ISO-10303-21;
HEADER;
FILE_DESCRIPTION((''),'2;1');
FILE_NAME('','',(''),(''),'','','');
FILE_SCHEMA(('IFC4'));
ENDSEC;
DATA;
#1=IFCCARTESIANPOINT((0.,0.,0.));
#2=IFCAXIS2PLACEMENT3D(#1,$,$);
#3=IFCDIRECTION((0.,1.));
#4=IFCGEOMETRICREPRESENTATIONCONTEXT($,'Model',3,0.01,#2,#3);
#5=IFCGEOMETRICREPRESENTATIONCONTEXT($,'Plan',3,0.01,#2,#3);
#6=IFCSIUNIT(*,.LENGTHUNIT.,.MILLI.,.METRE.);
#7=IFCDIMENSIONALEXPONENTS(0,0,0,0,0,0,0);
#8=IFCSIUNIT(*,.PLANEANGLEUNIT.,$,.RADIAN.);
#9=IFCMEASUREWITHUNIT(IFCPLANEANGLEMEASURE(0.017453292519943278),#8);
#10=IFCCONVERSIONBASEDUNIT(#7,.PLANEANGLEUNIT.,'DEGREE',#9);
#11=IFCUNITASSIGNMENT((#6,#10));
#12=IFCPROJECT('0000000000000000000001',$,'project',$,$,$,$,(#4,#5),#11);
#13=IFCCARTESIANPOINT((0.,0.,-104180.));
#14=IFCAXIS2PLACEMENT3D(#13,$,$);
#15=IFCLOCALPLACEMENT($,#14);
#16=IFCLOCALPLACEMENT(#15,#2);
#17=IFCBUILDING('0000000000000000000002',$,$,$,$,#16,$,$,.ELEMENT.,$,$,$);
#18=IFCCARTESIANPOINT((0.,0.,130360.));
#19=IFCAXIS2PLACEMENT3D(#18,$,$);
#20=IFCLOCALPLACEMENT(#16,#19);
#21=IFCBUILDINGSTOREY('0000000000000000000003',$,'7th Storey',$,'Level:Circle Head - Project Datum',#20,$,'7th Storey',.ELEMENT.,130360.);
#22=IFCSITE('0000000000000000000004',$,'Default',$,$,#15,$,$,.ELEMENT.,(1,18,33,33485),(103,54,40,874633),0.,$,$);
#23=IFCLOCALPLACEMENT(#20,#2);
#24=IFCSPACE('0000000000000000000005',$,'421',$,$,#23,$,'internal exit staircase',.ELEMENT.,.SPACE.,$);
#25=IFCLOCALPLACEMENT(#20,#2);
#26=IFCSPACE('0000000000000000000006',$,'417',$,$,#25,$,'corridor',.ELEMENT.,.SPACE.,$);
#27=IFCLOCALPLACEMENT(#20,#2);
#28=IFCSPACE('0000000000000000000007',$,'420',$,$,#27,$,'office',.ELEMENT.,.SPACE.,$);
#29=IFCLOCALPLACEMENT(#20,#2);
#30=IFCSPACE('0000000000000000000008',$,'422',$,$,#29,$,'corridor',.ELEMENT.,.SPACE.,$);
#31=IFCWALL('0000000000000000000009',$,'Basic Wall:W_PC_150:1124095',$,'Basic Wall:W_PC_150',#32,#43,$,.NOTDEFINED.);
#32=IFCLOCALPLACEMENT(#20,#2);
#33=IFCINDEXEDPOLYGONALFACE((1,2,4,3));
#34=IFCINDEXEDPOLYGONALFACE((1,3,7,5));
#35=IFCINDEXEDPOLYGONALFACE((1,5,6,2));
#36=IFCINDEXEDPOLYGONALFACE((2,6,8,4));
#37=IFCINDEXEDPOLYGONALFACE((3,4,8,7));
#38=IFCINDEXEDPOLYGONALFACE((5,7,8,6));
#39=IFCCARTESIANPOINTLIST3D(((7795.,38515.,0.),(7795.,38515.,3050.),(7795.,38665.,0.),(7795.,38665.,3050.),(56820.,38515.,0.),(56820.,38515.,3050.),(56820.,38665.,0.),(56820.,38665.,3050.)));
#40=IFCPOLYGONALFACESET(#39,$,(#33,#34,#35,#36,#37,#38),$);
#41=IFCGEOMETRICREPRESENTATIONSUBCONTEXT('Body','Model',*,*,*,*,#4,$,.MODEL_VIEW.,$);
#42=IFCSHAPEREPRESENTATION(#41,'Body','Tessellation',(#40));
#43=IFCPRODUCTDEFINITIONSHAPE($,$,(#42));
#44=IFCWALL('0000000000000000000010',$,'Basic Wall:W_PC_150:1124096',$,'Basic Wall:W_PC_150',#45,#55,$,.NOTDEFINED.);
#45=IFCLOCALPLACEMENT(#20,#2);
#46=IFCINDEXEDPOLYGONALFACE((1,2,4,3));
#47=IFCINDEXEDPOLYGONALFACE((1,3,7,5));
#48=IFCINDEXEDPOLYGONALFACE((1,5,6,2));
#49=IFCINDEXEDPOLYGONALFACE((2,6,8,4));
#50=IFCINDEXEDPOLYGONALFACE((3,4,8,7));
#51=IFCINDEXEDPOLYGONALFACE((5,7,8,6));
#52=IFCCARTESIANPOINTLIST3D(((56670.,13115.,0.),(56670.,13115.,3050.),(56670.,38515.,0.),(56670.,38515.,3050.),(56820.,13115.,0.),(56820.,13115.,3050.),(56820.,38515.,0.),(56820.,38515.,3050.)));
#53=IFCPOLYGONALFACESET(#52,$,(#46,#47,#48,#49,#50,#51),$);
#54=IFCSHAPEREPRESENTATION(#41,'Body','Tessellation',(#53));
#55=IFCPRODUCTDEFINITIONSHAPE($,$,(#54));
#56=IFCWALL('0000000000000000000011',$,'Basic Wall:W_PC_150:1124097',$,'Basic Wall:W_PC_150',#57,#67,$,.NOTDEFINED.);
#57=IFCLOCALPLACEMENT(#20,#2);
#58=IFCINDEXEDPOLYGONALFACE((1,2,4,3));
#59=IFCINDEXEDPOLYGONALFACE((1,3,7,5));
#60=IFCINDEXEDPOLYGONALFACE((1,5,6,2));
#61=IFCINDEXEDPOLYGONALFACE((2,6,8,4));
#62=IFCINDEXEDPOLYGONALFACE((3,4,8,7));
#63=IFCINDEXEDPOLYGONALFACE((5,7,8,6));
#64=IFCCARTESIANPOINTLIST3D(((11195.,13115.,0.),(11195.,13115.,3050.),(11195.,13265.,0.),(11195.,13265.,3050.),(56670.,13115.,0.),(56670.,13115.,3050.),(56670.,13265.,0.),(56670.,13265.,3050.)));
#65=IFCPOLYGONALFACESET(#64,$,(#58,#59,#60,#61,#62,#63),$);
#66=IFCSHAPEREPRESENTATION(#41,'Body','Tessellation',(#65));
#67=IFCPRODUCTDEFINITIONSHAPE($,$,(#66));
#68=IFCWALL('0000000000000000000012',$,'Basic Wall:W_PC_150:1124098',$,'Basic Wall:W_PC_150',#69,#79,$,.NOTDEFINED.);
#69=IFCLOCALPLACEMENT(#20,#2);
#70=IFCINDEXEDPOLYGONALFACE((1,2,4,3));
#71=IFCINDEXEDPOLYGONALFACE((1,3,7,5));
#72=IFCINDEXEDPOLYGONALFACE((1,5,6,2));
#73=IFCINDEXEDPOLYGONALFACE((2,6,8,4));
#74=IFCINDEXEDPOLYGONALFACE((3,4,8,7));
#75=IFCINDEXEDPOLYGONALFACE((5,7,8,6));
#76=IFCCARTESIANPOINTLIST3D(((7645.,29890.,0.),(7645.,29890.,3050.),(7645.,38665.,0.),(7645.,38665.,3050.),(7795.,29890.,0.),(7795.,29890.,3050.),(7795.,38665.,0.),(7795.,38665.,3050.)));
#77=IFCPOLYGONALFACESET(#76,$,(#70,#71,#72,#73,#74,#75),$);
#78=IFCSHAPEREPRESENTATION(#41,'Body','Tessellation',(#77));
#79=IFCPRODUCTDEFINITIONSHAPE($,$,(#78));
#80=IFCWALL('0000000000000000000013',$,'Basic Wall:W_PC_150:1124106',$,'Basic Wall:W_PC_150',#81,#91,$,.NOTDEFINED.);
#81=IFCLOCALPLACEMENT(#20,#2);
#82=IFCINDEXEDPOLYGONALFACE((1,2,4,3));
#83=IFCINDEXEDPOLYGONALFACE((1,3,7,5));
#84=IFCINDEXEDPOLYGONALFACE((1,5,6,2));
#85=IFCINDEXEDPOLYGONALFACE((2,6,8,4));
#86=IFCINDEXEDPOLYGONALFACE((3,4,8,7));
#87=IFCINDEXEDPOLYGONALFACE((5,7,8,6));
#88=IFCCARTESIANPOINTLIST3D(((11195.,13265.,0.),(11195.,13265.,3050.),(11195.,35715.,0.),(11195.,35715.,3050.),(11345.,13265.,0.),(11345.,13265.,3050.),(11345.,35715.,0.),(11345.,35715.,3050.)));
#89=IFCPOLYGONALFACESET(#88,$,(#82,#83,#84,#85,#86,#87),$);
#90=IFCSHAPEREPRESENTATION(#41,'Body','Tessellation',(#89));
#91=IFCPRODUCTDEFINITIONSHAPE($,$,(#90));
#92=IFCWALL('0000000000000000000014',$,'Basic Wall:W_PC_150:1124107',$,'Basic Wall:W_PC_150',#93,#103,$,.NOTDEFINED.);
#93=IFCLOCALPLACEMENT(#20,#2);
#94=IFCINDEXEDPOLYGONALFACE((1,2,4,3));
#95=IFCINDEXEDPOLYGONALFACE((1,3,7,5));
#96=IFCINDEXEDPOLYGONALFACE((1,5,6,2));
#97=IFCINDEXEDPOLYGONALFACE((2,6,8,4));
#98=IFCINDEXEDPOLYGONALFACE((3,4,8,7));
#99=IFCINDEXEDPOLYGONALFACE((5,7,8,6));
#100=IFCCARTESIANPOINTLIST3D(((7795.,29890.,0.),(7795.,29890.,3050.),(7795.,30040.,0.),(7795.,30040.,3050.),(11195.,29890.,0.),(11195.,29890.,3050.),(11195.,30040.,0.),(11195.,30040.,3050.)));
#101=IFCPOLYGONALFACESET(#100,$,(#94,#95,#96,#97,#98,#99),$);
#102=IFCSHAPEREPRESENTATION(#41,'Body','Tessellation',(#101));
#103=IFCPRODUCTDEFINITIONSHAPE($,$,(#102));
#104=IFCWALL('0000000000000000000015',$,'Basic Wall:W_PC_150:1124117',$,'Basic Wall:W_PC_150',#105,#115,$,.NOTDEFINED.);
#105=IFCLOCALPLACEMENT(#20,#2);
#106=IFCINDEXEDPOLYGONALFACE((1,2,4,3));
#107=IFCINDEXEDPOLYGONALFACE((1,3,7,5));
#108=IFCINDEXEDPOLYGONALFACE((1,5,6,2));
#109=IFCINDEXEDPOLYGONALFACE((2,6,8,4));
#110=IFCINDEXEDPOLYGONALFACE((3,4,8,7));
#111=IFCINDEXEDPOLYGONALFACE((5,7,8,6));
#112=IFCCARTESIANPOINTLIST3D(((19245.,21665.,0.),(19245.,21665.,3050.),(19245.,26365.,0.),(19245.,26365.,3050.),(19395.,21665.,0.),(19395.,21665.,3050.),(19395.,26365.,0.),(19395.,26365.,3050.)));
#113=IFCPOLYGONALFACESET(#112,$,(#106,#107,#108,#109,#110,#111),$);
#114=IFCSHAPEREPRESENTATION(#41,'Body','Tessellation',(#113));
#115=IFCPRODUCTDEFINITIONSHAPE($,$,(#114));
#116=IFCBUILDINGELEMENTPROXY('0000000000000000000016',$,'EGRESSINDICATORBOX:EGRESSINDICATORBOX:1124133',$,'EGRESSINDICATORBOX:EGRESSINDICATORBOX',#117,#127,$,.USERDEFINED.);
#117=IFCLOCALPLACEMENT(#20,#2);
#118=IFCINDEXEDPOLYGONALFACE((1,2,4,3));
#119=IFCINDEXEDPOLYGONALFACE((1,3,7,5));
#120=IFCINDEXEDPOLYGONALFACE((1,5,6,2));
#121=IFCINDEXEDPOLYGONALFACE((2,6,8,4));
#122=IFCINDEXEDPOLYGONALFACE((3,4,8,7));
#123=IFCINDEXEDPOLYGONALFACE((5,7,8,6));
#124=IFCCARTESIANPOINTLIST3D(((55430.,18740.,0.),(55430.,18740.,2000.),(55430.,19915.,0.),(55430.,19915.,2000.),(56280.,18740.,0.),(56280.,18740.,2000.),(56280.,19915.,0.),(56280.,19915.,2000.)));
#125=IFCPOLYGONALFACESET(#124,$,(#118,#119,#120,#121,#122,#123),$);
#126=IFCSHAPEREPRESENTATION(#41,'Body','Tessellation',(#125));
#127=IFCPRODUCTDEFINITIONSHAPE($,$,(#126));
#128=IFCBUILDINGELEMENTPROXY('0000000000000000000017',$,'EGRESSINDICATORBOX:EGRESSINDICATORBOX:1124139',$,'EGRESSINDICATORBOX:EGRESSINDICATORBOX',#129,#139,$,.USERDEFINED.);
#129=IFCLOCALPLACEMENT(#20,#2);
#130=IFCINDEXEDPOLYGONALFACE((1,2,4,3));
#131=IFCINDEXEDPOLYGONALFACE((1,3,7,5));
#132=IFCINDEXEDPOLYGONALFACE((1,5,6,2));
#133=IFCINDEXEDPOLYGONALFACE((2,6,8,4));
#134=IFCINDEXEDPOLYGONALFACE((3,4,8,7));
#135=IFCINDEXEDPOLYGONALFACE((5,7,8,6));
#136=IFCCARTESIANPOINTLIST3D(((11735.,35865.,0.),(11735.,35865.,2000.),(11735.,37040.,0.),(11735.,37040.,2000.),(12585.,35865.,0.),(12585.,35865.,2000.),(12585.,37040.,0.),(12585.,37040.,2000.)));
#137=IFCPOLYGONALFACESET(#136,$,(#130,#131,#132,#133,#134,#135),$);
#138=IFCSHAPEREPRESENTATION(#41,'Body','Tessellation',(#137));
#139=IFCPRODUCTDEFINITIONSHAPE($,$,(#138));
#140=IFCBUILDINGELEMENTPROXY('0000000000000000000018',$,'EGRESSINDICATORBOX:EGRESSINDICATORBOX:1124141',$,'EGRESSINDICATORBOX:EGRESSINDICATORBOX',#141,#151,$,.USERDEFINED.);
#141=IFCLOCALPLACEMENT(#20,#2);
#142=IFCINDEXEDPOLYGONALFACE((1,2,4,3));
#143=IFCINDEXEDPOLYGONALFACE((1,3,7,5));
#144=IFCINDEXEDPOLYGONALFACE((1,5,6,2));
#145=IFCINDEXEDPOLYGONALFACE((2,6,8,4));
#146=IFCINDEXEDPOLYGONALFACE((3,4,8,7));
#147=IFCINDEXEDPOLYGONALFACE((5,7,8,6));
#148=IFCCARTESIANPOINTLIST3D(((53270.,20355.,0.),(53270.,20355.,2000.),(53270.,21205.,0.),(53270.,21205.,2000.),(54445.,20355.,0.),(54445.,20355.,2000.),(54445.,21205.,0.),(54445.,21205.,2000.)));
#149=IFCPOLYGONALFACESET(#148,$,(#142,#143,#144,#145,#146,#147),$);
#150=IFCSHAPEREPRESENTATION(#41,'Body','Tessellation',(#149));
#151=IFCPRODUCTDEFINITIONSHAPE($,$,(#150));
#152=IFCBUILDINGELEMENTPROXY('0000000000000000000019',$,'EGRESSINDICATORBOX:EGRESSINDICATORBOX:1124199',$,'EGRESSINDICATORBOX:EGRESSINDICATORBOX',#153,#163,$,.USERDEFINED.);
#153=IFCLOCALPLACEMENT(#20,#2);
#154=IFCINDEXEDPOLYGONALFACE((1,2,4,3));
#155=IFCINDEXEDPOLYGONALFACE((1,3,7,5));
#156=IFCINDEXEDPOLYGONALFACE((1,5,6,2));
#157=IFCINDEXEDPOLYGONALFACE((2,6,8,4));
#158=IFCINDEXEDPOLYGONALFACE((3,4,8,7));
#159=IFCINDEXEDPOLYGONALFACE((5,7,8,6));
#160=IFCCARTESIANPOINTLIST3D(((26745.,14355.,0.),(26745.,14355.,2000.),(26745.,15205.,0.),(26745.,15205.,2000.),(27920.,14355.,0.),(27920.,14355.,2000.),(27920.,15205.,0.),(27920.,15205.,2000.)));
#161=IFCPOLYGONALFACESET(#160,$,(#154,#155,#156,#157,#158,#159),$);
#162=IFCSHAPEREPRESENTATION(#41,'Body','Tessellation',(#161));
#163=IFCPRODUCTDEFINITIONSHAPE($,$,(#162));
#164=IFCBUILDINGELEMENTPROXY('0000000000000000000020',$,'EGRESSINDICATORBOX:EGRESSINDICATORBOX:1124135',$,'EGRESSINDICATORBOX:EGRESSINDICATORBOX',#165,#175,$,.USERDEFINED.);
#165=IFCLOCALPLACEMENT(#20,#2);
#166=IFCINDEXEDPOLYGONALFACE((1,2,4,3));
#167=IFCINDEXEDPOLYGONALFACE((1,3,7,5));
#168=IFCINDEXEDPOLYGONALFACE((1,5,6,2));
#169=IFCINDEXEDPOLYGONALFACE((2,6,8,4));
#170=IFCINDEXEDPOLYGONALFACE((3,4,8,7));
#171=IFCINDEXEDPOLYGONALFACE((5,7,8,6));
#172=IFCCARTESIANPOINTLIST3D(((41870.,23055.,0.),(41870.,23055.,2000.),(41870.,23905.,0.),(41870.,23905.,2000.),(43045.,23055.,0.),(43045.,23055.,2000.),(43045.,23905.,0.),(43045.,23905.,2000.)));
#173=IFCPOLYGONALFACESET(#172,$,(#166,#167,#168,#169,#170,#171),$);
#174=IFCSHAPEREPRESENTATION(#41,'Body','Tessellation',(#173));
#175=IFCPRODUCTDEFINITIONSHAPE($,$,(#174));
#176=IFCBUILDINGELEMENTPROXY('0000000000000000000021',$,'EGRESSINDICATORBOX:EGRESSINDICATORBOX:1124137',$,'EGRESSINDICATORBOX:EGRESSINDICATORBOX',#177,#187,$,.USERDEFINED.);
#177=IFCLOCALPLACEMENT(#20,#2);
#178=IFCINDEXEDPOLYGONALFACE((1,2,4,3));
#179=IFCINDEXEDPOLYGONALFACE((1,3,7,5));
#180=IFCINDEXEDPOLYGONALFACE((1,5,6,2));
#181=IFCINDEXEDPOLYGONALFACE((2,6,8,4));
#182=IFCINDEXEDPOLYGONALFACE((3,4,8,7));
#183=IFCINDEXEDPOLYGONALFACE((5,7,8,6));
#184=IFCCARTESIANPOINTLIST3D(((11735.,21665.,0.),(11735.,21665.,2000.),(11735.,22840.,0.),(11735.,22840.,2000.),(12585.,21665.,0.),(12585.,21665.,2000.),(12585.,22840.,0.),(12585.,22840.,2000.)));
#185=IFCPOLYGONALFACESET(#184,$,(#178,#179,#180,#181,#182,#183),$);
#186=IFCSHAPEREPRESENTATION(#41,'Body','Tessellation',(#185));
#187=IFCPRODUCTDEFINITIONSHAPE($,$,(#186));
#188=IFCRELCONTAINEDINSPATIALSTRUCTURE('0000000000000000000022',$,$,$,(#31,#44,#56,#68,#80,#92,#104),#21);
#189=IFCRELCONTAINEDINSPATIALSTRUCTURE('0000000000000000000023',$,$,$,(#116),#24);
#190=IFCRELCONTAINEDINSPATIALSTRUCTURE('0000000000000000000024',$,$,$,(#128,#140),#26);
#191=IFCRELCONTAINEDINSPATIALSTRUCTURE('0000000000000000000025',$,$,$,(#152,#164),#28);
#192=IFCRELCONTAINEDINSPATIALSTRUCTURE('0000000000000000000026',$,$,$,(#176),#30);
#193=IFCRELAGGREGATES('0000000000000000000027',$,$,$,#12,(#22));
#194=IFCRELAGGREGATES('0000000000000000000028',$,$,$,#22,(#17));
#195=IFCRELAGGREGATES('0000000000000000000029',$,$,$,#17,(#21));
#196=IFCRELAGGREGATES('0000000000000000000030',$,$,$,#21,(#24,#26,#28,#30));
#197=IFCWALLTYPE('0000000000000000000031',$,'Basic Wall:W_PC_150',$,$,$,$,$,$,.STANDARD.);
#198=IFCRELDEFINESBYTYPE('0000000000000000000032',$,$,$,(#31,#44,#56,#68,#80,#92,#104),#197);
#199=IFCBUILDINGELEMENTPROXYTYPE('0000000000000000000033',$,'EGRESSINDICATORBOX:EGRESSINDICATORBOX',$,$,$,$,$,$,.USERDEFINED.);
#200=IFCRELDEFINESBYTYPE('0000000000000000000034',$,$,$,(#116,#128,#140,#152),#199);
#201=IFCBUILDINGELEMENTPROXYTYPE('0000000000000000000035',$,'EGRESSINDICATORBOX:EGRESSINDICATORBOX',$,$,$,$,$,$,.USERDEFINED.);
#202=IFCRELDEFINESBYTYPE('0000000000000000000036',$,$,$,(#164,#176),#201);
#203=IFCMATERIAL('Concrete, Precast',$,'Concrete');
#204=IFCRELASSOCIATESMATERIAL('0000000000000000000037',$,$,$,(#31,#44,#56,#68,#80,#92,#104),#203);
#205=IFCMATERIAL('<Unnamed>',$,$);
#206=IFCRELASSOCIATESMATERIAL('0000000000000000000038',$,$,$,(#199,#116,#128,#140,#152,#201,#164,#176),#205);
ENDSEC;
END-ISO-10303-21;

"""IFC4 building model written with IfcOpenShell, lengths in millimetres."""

from ifc_helpers import new_model, entity, si_unit, converted_unit, direction, frame, origin, place, context, subcontext, project, spatial, indexed_curve, outline, extrude, source, transform, mapped, material, type_object, type_shapes, element, save


model = new_model("IFC4")

# Units and contexts
model_context = context("Model", 3, precision=0.01, world=origin(), true_north=direction((0.0, 1.0)))
plan_context = context("Plan", 3, precision=0.01, world=origin(), true_north=direction((0.0, 1.0)))
body_context = subcontext(model_context, "Body", "Model", "MODEL_VIEW")
ifc_project = project(units=[si_unit("LENGTHUNIT", "METRE", prefix="MILLI"), converted_unit("PLANEANGLEUNIT", "DEGREE", entity("IfcPlaneAngleMeasure", 0.017453292519943278), si_unit("PLANEANGLEUNIT", "RADIAN"), dimensions=[0, 0, 0, 0, 0, 0, 0])], contexts=[model_context, plan_context])

# Site, building, storey
site_placement = place(None, frame((0.0, 0.0, -104180.0)))
site = spatial("IfcSite", under=ifc_project, at=site_placement, Name="Default", CompositionType="ELEMENT", RefLatitude=(1, 18, 33, 33485), RefLongitude=(103, 54, 40, 874633), RefElevation=0.0)
building_placement = place(site_placement, origin())
building = spatial("IfcBuilding", under=site, at=building_placement, CompositionType="ELEMENT")
storey_placement = place(building_placement, frame((0.0, 0.0, 130360.0)))
storey = spatial("IfcBuildingStorey", under=building, at=storey_placement, Name="7th Storey", ObjectType="Level:Circle Head - Project Datum", LongName="7th Storey", CompositionType="ELEMENT", Elevation=130360.0)

# Shared definitions
ifc_material_1 = material(Name="Concrete, Precast", Category="Concrete")

# Walls
wall_type = type_object("IfcWallType", Name="Basic Wall:W_PC_150", PredefinedType="STANDARD")
wall_1_placement = place(storey_placement, frame((56820.0, 38590.0, 0.0), z_axis=(0.0, 0.0, 1.0), x_axis=(-1.0, 0.0, 0.0)))
element("IfcWall", 1, at=wall_1_placement, inside=storey, type_object=wall_type, material=ifc_material_1, Name="Basic Wall:W_PC_150:1124095", ObjectType="Basic Wall:W_PC_150", PredefinedType="NOTDEFINED", context=body_context, shape_type="SweptSolid", body=[
    extrude(outline(indexed_curve([(49025.0, 75.0), (0.0, 75.0), (0.0, -75.0), (49025.0, -75.0), (49025.0, 75.0)], self_intersect=False)), origin(), (0.0, 0.0, 1.0), 3050.0),
])
wall_2_placement = place(storey_placement, frame((56745.0, 13115.0, 0.0), z_axis=(0.0, 0.0, 1.0), x_axis=(0.0, 1.0, 0.0)))
element("IfcWall", 2, at=wall_2_placement, inside=storey, type_object=wall_type, material=ifc_material_1, Name="Basic Wall:W_PC_150:1124096", ObjectType="Basic Wall:W_PC_150", PredefinedType="NOTDEFINED", context=body_context, shape_type="SweptSolid", body=[
    extrude(outline(indexed_curve([(25400.0, 75.0), (0.0, 75.0), (0.0, -75.0), (25400.0, -75.0), (25400.0, 75.0)], self_intersect=False)), origin(), (0.0, 0.0, 1.0), 3050.0),
])
wall_3_placement = place(storey_placement, frame((11195.0, 13190.0, 0.0)))
element("IfcWall", 3, at=wall_3_placement, inside=storey, type_object=wall_type, material=ifc_material_1, Name="Basic Wall:W_PC_150:1124097", ObjectType="Basic Wall:W_PC_150", PredefinedType="NOTDEFINED", context=body_context, shape_type="SweptSolid", body=[
    extrude(outline(indexed_curve([(45475.0, 75.0), (0.0, 75.0), (0.0, -75.0), (45475.0, -75.0), (45475.0, 75.0)], self_intersect=False)), origin(), (0.0, 0.0, 1.0), 3050.0),
])
wall_4_placement = place(storey_placement, frame((7720.0, 38665.0, 0.0), z_axis=(0.0, 0.0, 1.0), x_axis=(0.0, -1.0, 0.0)))
element("IfcWall", 4, at=wall_4_placement, inside=storey, type_object=wall_type, material=ifc_material_1, Name="Basic Wall:W_PC_150:1124098", ObjectType="Basic Wall:W_PC_150", PredefinedType="NOTDEFINED", context=body_context, shape_type="SweptSolid", body=[
    extrude(outline(indexed_curve([(8775.0, 75.0), (0.0, 75.0), (0.0, -75.0), (8775.0, -75.0), (8775.0, 75.0)], self_intersect=False)), origin(), (0.0, 0.0, 1.0), 3050.0),
])
wall_5_placement = place(storey_placement, frame((11270.0, 35715.0, 0.0), z_axis=(0.0, 0.0, 1.0), x_axis=(0.0, -1.0, 0.0)))
element("IfcWall", 5, at=wall_5_placement, inside=storey, type_object=wall_type, material=ifc_material_1, Name="Basic Wall:W_PC_150:1124106", ObjectType="Basic Wall:W_PC_150", PredefinedType="NOTDEFINED", context=body_context, shape_type="SweptSolid", body=[
    extrude(outline(indexed_curve([(22450.0, 75.0), (0.0, 75.0), (0.0, -75.0), (22450.0, -75.0), (22450.0, 75.0)], self_intersect=False)), origin(), (0.0, 0.0, 1.0), 3050.0),
])
wall_6_placement = place(storey_placement, frame((7795.0, 29965.0, 0.0)))
element("IfcWall", 6, at=wall_6_placement, inside=storey, type_object=wall_type, material=ifc_material_1, Name="Basic Wall:W_PC_150:1124107", ObjectType="Basic Wall:W_PC_150", PredefinedType="NOTDEFINED", context=body_context, shape_type="SweptSolid", body=[
    extrude(outline(indexed_curve([(3400.0, 75.0), (0.0, 75.0), (0.0, -75.0), (3400.0, -75.0), (3400.0, 75.0)], self_intersect=False)), origin(), (0.0, 0.0, 1.0), 3050.0),
])
wall_7_placement = place(storey_placement, frame((19320.0, 21665.0, 0.0), z_axis=(0.0, 0.0, 1.0), x_axis=(0.0, 1.0, 0.0)))
element("IfcWall", 7, at=wall_7_placement, inside=storey, type_object=wall_type, material=ifc_material_1, Name="Basic Wall:W_PC_150:1124117", ObjectType="Basic Wall:W_PC_150", PredefinedType="NOTDEFINED", context=body_context, shape_type="SweptSolid", body=[
    extrude(outline(indexed_curve([(4700.0, 75.0), (0.0, 75.0), (0.0, -75.0), (4700.0, -75.0), (4700.0, 75.0)], self_intersect=False)), origin(), (0.0, 0.0, 1.0), 3050.0),
])

# Shared definitions
space_1_placement = place(storey_placement, origin())
space_1 = spatial("IfcSpace", under=storey, at=space_1_placement, Name="421", LongName="internal exit staircase", CompositionType="ELEMENT", PredefinedType="SPACE")

# Building element proxy
ifc_material_2 = material(Name="<Unnamed>")
building_element_proxy_type_1 = type_object("IfcBuildingElementProxyType", Name="EGRESSINDICATORBOX:EGRESSINDICATORBOX", PredefinedType="USERDEFINED", material=ifc_material_2)
shared_shape_1 = source(origin(), body_context, "Body", "SweptSolid", [
    extrude(outline(indexed_curve([(-587.5, -425.0), (587.5, -425.0), (587.5, 425.0), (-587.5, 425.0), (-587.5, -425.0)], self_intersect=False)), frame((0.0, 0.0, 0.0), z_axis=(0.0, 0.0, 1.0), x_axis=(0.0, 1.0, 0.0)), (0.0, 0.0, 1.0), 2000.0),
])
type_shapes(building_element_proxy_type_1, [shared_shape_1])
proxy_1_placement = place(space_1_placement, frame((55855.0, 19327.5, 0.0)))
element("IfcBuildingElementProxy", 8, at=proxy_1_placement, inside=space_1, type_object=building_element_proxy_type_1, material=ifc_material_2, Name="EGRESSINDICATORBOX:EGRESSINDICATORBOX:1124133", ObjectType="EGRESSINDICATORBOX:EGRESSINDICATORBOX", PredefinedType="USERDEFINED", context=body_context, shape_type="MappedRepresentation", body=[
    mapped(shared_shape_1, transform((0.0, 0.0, 0.0), scale=1.0)),
])

# Shared definitions
space_2_placement = place(storey_placement, origin())
space_2 = spatial("IfcSpace", under=storey, at=space_2_placement, Name="417", LongName="corridor", CompositionType="ELEMENT", PredefinedType="SPACE")

# Building element proxies
for number, where, z_axis, x_axis, name in (
    (9, (12160.0, 36452.5, 0.0), (0.0, 0.0, 1.0), (-1.0, 0.0, 0.0), "EGRESSINDICATORBOX:EGRESSINDICATORBOX:1124139"),
    (10, (53857.5, 20780.0, 0.0), (0.0, 0.0, 1.0), (0.0, 1.0, 0.0), "EGRESSINDICATORBOX:EGRESSINDICATORBOX:1124141"),
):
    element("IfcBuildingElementProxy", number, at=place(space_2_placement, frame(where, z_axis=z_axis, x_axis=x_axis)), inside=space_2, type_object=building_element_proxy_type_1, material=ifc_material_2, Name=name, ObjectType="EGRESSINDICATORBOX:EGRESSINDICATORBOX", PredefinedType="USERDEFINED", context=body_context, shape_type="MappedRepresentation", body=[
        mapped(shared_shape_1, transform((0.0, 0.0, 0.0), scale=1.0)),
    ])

# Shared definitions
space_3_placement = place(storey_placement, origin())
space_3 = spatial("IfcSpace", under=storey, at=space_3_placement, Name="420", LongName="office", CompositionType="ELEMENT", PredefinedType="SPACE")

# Building element proxies
proxy_2_placement = place(space_3_placement, frame((27332.5, 14780.0, 0.0), z_axis=(0.0, 0.0, 1.0), x_axis=(0.0, 1.0, 0.0)))
element("IfcBuildingElementProxy", 11, at=proxy_2_placement, inside=space_3, type_object=building_element_proxy_type_1, material=ifc_material_2, Name="EGRESSINDICATORBOX:EGRESSINDICATORBOX:1124199", ObjectType="EGRESSINDICATORBOX:EGRESSINDICATORBOX", PredefinedType="USERDEFINED", context=body_context, shape_type="MappedRepresentation", body=[
    mapped(shared_shape_1, transform((0.0, 0.0, 0.0), scale=1.0)),
])
building_element_proxy_type_2 = type_object("IfcBuildingElementProxyType", Name="EGRESSINDICATORBOX:EGRESSINDICATORBOX", PredefinedType="USERDEFINED", material=ifc_material_2)
shared_shape_2 = source(origin(), body_context, "Body", "SweptSolid", [
    extrude(outline(indexed_curve([(-425.0, -587.5), (425.0, -587.5), (425.0, 587.5), (-425.0, 587.5), (-425.0, -587.5)], self_intersect=False)), frame((0.0, 0.0, 0.0), z_axis=(0.0, 0.0, 1.0), x_axis=(-1.0, 0.0, 0.0)), (0.0, 0.0, 1.0), 2000.0),
])
type_shapes(building_element_proxy_type_2, [shared_shape_2])
proxy_3_placement = place(space_3_placement, frame((42457.5, 23480.0, 0.0), z_axis=(0.0, 0.0, 1.0), x_axis=(0.0, -1.0, 0.0)))
element("IfcBuildingElementProxy", 12, at=proxy_3_placement, inside=space_3, type_object=building_element_proxy_type_2, material=ifc_material_2, Name="EGRESSINDICATORBOX:EGRESSINDICATORBOX:1124135", ObjectType="EGRESSINDICATORBOX:EGRESSINDICATORBOX", PredefinedType="USERDEFINED", context=body_context, shape_type="MappedRepresentation", body=[
    mapped(shared_shape_2, transform((0.0, 0.0, 0.0), scale=1.0)),
])

# Shared definitions
space_4_placement = place(storey_placement, origin())
space_4 = spatial("IfcSpace", under=storey, at=space_4_placement, Name="422", LongName="corridor", CompositionType="ELEMENT", PredefinedType="SPACE")

# Building element proxy
proxy_4_placement = place(space_4_placement, frame((12160.0, 22252.5, 0.0)))
element("IfcBuildingElementProxy", 13, at=proxy_4_placement, inside=space_4, type_object=building_element_proxy_type_2, material=ifc_material_2, Name="EGRESSINDICATORBOX:EGRESSINDICATORBOX:1124137", ObjectType="EGRESSINDICATORBOX:EGRESSINDICATORBOX", PredefinedType="USERDEFINED", context=body_context, shape_type="MappedRepresentation", body=[
    mapped(shared_shape_2, transform((0.0, 0.0, 0.0), scale=1.0)),
])

save(model, "model.ifc")
